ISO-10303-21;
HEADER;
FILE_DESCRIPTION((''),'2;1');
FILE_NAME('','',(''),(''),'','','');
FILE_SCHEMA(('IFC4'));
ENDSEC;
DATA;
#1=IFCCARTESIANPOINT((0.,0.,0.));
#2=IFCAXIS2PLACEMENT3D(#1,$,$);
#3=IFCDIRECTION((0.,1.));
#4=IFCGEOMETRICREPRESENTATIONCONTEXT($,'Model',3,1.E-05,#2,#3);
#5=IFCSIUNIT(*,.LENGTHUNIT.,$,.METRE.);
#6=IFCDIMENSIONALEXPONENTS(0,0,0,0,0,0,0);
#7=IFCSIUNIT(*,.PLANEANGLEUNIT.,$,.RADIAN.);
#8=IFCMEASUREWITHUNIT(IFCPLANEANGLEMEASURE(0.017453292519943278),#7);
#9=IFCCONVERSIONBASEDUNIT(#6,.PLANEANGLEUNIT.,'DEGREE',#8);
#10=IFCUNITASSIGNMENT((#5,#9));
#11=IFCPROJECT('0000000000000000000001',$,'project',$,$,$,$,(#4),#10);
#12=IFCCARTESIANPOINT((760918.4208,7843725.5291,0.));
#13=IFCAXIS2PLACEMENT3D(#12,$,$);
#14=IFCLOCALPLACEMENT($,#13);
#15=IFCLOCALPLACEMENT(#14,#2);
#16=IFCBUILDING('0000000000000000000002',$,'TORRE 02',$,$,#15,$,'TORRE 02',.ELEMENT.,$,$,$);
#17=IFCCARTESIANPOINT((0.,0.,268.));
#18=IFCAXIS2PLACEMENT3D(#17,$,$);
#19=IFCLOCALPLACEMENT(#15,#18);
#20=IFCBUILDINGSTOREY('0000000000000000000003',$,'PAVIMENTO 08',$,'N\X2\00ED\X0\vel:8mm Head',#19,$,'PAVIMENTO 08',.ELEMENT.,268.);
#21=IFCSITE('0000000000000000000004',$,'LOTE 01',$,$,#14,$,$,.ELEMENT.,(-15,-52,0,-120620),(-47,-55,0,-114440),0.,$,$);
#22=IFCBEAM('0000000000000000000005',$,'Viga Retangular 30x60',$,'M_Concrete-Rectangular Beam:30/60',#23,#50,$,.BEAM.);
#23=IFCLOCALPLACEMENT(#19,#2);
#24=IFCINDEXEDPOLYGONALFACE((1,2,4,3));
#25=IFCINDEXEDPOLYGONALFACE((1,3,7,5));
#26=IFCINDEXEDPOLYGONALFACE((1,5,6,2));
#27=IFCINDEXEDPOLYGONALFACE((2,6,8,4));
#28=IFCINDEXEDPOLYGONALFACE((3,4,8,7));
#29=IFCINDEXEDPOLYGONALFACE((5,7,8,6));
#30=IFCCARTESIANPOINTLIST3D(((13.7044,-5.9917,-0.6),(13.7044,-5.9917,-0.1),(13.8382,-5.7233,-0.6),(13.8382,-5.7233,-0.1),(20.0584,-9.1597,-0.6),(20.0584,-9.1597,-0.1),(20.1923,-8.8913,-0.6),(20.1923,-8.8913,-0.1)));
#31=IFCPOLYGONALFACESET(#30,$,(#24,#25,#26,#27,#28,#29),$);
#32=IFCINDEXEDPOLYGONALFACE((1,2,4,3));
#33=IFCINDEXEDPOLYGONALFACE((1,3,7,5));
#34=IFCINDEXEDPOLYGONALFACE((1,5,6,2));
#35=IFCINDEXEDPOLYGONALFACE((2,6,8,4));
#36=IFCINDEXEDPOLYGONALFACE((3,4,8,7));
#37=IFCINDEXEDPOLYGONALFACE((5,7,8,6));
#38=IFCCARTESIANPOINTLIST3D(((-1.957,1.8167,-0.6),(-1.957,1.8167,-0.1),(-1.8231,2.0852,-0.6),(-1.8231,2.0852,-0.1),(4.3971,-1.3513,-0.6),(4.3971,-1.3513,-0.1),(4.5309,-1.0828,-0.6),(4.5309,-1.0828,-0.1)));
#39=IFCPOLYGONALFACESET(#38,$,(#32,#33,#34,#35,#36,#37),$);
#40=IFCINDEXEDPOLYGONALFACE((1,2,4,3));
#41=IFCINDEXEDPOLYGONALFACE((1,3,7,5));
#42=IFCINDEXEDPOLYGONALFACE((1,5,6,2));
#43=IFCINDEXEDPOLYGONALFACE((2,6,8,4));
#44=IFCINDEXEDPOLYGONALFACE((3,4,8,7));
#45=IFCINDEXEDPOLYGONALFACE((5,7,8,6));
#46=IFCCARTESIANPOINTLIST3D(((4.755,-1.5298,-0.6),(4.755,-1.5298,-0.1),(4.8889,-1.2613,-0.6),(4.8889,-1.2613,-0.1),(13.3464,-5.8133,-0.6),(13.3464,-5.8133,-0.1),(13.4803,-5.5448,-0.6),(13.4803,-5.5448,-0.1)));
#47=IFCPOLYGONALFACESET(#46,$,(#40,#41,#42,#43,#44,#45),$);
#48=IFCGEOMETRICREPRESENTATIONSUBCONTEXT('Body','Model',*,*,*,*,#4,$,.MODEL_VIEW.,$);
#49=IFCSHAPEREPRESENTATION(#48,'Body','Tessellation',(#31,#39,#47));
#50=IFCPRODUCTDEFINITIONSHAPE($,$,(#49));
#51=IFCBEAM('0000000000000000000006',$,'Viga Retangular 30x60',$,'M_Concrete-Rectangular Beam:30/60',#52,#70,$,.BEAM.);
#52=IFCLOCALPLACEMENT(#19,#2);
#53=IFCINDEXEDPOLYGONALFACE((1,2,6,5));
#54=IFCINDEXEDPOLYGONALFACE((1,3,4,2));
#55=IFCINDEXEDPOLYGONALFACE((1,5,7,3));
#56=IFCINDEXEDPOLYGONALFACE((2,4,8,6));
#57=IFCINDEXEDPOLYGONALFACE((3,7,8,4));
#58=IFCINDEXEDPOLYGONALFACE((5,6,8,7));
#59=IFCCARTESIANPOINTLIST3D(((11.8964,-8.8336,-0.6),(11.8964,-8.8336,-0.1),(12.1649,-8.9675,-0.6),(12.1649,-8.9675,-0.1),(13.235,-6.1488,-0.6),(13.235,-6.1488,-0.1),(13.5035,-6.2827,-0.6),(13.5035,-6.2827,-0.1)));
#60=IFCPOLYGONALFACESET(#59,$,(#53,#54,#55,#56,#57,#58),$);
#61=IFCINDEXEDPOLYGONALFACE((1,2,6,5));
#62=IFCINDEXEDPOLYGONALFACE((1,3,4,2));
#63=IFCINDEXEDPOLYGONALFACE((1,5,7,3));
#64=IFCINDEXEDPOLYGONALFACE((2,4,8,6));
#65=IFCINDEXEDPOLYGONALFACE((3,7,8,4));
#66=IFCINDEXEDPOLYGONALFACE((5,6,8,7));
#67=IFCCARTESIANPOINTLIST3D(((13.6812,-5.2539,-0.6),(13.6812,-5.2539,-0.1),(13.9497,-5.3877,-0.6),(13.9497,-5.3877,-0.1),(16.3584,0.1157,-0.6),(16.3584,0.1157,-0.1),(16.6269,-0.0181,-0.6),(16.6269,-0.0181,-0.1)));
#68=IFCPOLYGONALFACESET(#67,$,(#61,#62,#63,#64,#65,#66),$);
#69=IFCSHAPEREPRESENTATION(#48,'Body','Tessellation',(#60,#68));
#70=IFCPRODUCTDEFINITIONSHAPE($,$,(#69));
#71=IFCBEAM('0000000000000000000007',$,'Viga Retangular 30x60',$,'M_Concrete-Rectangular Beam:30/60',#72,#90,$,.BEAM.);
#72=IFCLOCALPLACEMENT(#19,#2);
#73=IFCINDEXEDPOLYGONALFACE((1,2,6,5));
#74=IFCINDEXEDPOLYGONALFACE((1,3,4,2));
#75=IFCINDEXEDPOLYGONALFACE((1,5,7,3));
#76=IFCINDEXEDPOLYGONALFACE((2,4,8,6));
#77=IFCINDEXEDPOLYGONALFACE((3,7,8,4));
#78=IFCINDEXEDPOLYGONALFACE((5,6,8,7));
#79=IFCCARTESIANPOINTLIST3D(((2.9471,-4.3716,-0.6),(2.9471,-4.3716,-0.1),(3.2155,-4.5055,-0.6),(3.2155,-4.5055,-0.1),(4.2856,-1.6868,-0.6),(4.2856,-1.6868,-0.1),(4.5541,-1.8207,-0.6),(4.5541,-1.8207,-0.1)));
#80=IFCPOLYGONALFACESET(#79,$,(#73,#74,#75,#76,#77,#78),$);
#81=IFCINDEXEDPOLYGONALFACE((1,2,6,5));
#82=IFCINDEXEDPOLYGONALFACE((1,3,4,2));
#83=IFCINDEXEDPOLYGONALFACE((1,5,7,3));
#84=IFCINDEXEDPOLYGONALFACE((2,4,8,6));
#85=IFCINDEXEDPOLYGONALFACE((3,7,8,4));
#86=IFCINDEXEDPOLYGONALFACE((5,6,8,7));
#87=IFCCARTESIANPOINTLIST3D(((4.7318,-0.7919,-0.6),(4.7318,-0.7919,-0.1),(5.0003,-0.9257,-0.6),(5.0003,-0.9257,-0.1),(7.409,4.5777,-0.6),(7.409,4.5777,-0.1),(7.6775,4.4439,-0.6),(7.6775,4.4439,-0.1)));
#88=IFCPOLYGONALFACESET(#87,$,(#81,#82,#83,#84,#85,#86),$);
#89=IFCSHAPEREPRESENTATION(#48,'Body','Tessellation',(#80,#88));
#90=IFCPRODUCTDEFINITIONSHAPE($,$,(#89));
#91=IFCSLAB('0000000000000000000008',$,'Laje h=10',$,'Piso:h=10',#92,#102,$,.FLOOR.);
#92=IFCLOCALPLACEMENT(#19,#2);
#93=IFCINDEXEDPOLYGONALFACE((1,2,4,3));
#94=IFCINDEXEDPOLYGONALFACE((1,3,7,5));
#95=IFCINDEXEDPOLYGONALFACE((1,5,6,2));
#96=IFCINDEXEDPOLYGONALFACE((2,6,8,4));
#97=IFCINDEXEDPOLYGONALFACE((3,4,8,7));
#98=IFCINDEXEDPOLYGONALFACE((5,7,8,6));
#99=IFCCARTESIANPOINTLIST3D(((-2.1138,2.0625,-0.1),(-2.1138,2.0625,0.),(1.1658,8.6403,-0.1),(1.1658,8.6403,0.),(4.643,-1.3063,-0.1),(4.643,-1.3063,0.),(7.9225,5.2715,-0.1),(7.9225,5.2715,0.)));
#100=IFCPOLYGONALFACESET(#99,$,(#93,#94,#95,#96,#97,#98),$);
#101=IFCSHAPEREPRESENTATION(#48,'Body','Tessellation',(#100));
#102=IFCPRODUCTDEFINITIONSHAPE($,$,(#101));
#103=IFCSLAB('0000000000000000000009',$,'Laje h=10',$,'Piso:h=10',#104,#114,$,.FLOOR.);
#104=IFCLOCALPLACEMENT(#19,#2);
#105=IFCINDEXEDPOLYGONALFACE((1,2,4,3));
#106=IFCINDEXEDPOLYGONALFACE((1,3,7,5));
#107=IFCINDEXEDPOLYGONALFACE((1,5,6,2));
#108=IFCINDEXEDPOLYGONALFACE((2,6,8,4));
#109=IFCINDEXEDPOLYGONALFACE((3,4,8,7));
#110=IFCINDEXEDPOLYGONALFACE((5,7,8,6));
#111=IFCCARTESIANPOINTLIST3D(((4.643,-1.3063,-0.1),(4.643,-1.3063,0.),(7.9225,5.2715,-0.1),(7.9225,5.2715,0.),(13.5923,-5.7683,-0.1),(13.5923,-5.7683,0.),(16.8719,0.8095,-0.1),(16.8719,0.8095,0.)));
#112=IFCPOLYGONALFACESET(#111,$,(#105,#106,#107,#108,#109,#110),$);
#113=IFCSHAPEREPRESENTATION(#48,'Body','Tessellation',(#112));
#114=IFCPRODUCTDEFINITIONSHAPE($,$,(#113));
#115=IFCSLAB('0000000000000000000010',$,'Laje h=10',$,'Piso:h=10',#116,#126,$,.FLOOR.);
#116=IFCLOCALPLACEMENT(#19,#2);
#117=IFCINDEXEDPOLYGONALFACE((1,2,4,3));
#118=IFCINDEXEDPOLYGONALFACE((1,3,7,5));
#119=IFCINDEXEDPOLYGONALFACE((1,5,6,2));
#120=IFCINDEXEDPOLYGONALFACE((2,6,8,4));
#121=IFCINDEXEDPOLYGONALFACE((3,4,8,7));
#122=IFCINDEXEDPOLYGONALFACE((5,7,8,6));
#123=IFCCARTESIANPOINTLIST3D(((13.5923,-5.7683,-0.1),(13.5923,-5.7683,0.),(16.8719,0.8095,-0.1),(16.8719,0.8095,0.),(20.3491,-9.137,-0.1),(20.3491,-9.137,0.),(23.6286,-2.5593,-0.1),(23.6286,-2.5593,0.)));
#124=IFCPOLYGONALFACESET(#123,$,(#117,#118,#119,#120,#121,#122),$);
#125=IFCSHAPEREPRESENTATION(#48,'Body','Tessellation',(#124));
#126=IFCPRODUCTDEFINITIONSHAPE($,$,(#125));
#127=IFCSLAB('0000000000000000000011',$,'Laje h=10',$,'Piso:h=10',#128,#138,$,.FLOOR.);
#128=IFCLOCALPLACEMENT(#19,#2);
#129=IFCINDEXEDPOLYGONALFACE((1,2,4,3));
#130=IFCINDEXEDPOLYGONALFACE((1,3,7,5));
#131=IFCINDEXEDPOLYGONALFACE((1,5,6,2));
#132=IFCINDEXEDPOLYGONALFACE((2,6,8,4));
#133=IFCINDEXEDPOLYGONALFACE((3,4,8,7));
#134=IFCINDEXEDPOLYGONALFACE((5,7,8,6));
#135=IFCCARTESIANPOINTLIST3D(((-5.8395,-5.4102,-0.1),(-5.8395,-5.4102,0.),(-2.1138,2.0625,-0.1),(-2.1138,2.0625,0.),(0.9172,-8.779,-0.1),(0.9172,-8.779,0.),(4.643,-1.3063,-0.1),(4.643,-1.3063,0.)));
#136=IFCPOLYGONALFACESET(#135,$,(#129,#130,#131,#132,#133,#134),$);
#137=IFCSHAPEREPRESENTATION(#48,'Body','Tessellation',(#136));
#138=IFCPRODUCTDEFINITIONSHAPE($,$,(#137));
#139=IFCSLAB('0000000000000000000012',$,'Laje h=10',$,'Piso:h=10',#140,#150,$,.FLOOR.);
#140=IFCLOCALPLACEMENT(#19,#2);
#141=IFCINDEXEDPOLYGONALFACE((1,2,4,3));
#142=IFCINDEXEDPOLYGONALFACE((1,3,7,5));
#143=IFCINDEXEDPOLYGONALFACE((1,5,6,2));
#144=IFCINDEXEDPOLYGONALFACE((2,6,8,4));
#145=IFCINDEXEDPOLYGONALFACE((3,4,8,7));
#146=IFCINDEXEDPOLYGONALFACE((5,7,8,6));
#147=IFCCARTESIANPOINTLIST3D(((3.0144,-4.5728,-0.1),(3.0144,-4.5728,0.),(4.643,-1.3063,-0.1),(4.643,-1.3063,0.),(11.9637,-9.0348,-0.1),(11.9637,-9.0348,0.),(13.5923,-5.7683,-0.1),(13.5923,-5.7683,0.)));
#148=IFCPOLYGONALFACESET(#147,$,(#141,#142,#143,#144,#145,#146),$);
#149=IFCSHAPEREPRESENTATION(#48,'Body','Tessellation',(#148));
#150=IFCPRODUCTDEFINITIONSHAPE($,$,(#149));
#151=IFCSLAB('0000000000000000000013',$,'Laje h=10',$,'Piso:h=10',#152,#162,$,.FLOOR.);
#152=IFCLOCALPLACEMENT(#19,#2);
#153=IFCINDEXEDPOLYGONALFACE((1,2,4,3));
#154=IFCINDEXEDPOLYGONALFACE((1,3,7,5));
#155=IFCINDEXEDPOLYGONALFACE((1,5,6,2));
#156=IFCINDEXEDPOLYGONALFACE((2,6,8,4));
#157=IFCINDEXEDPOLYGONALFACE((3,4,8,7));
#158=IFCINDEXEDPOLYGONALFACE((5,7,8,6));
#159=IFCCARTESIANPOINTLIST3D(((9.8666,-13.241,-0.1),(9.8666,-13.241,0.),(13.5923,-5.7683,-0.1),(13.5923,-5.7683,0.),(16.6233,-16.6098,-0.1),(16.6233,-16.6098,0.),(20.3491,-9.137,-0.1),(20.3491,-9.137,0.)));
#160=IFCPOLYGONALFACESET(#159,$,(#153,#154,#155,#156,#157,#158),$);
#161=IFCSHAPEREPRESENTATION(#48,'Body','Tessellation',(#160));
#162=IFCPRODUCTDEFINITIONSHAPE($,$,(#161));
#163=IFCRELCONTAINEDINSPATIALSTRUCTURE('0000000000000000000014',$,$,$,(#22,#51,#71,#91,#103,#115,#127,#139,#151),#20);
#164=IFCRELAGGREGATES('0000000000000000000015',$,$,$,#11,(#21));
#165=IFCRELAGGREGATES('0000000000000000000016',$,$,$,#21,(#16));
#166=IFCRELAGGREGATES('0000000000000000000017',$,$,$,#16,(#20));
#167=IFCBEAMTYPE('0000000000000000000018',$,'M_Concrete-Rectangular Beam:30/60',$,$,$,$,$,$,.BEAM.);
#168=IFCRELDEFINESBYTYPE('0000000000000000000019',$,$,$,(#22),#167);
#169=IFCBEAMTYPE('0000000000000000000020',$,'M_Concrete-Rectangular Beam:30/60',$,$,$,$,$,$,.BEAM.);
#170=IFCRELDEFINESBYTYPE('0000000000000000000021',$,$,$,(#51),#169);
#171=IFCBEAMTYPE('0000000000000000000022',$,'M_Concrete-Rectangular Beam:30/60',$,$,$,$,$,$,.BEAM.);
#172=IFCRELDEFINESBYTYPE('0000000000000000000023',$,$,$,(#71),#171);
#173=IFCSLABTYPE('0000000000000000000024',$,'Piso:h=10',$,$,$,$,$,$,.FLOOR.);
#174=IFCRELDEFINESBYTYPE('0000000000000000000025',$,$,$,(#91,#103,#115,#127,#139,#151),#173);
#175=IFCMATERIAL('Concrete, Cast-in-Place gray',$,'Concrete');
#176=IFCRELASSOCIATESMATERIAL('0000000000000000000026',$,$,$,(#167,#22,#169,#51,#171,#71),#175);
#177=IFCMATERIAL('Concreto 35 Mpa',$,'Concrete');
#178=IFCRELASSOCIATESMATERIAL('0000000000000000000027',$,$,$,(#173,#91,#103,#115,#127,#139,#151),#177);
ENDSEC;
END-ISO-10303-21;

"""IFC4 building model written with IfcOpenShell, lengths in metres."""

from ifc_helpers import new_model, entity, si_unit, converted_unit, direction, frame, origin, place, context, subcontext, project, spatial, indexed_curve, outline, extrude, source, transform, mapped, material, type_object, type_shapes, element, save


model = new_model("IFC4")

# Units and contexts
model_context = context("Model", 3, precision=1e-05, world=origin(), true_north=direction((0.0, 1.0)))
body_context = subcontext(model_context, "Body", "Model", "MODEL_VIEW")
ifc_project = project(units=[si_unit("LENGTHUNIT", "METRE"), converted_unit("PLANEANGLEUNIT", "DEGREE", entity("IfcPlaneAngleMeasure", 0.017453292519943278), si_unit("PLANEANGLEUNIT", "RADIAN"), dimensions=[0, 0, 0, 0, 0, 0, 0])], contexts=[model_context])

# Site, building, storey
site_placement = place(None, frame((760918.4208, 7843725.5291, 0.0)))
site = spatial("IfcSite", under=ifc_project, at=site_placement, Name="LOTE 01", CompositionType="ELEMENT", RefLatitude=(-15, -52, 0, -120620), RefLongitude=(-47, -55, 0, -114440), RefElevation=0.0)
building_placement = place(site_placement, origin())
building = spatial("IfcBuilding", under=site, at=building_placement, Name="TORRE 02", LongName="TORRE 02", CompositionType="ELEMENT")
storey_placement = place(building_placement, frame((0.0, 0.0, 268.0)))
storey = spatial("IfcBuildingStorey", under=building, at=storey_placement, Name="PAVIMENTO 08", ObjectType="Nível:8mm Head", LongName="PAVIMENTO 08", CompositionType="ELEMENT", Elevation=268.0)

# Shared definitions
ifc_material_1 = material(Name="Concrete, Cast-in-Place gray", Category="Concrete")

# Beams
beam_type_1 = type_object("IfcBeamType", Name="M_Concrete-Rectangular Beam:30/60", PredefinedType="BEAM", material=ifc_material_1)
shared_shape_1 = source(origin(), body_context, "Body", "SweptSolid", [
    extrude(outline(indexed_curve([(-0.25, -0.15), (0.25, -0.15), (0.25, 0.15), (-0.25, 0.15), (-0.25, -0.15)], self_intersect=False)), frame((13.7713, -5.8575, 267.65), z_axis=(0.894934, -0.446198, 0.0), x_axis=(0.0, 0.0, -1.0)), (0.0, 0.0, 1.0), 7.1),
    extrude(outline(indexed_curve([(-0.25, -0.15), (0.25, -0.15), (0.25, 0.15), (-0.25, 0.15), (-0.25, -0.15)], self_intersect=False)), frame((-1.89, 1.951, 267.65), z_axis=(0.894934, -0.446198, 0.0), x_axis=(0.0, 0.0, -1.0)), (0.0, 0.0, 1.0), 7.1),
    extrude(outline(indexed_curve([(-0.25, -0.15), (0.25, -0.15), (0.25, 0.15), (-0.25, 0.15), (-0.25, -0.15)], self_intersect=False)), frame((4.822, -1.3955, 267.65), z_axis=(0.894934, -0.446198, 0.0), x_axis=(0.0, 0.0, -1.0)), (0.0, 0.0, 1.0), 9.6),
])
type_shapes(beam_type_1, [shared_shape_1])
beam_1_placement = place(storey_placement, frame((0.0, 0.0, -268.0)))
element("IfcBeam", 1, at=beam_1_placement, inside=storey, type_object=beam_type_1, material=ifc_material_1, Name="Viga Retangular 30x60", ObjectType="M_Concrete-Rectangular Beam:30/60", PredefinedType="BEAM", context=body_context, shape_type="MappedRepresentation", body=[
    mapped(shared_shape_1, transform((0.0, 0.0, 0.0), scale=1.0)),
])
beam_type_2 = type_object("IfcBeamType", Name="M_Concrete-Rectangular Beam:30/60", PredefinedType="BEAM", material=ifc_material_1)
shared_shape_2 = source(origin(), body_context, "Body", "SweptSolid", [
    extrude(outline(indexed_curve([(-0.25, -0.15), (0.25, -0.15), (0.25, 0.15), (-0.25, 0.15), (-0.25, -0.15)], self_intersect=False)), frame((12.0306, -8.9005, 267.65), z_axis=(0.446198, 0.894934, 0.0), x_axis=(0.0, 0.0, 1.0)), (0.0, 0.0, 1.0), 3.0),
    extrude(outline(indexed_curve([(-0.25, -0.15), (0.25, -0.15), (0.25, 0.15), (-0.25, 0.15), (-0.25, -0.15)], self_intersect=False)), frame((13.8154, -5.3208, 267.65), z_axis=(0.446198, 0.894934, 0.0), x_axis=(0.0, 0.0, 1.0)), (0.0, 0.0, 1.0), 6.0),
])
type_shapes(beam_type_2, [shared_shape_2])
beam_2_placement = place(storey_placement, frame((0.0, 0.0, -268.0)))
element("IfcBeam", 2, at=beam_2_placement, inside=storey, type_object=beam_type_2, material=ifc_material_1, Name="Viga Retangular 30x60", ObjectType="M_Concrete-Rectangular Beam:30/60", PredefinedType="BEAM", context=body_context, shape_type="MappedRepresentation", body=[
    mapped(shared_shape_2, transform((0.0, 0.0, 0.0), scale=1.0)),
])
beam_type_3 = type_object("IfcBeamType", Name="M_Concrete-Rectangular Beam:30/60", PredefinedType="BEAM", material=ifc_material_1)
shared_shape_3 = source(origin(), body_context, "Body", "SweptSolid", [
    extrude(outline(indexed_curve([(-0.25, -0.15), (0.25, -0.15), (0.25, 0.15), (-0.25, 0.15), (-0.25, -0.15)], self_intersect=False)), frame((3.0813, -4.4385, 267.65), z_axis=(0.446198, 0.894934, 0.0), x_axis=(0.0, 0.0, 1.0)), (0.0, 0.0, 1.0), 3.0),
    extrude(outline(indexed_curve([(-0.25, -0.15), (0.25, -0.15), (0.25, 0.15), (-0.25, 0.15), (-0.25, -0.15)], self_intersect=False)), frame((4.8661, -0.8588, 267.65), z_axis=(0.446198, 0.894934, 0.0), x_axis=(0.0, 0.0, 1.0)), (0.0, 0.0, 1.0), 6.0),
])
type_shapes(beam_type_3, [shared_shape_3])
beam_3_placement = place(storey_placement, frame((0.0, 0.0, -268.0)))
element("IfcBeam", 3, at=beam_3_placement, inside=storey, type_object=beam_type_3, material=ifc_material_1, Name="Viga Retangular 30x60", ObjectType="M_Concrete-Rectangular Beam:30/60", PredefinedType="BEAM", context=body_context, shape_type="MappedRepresentation", body=[
    mapped(shared_shape_3, transform((0.0, 0.0, 0.0), scale=1.0)),
])

# Slabs
ifc_material_2 = material(Name="Concreto 35 Mpa", Category="Concrete")
slab_type = type_object("IfcSlabType", Name="Piso:h=10", PredefinedType="FLOOR", material=ifc_material_2)
slab_1_placement = place(storey_placement, origin())
element("IfcSlab", 4, at=slab_1_placement, inside=storey, type_object=slab_type, material=ifc_material_2, Name="Laje h=10", ObjectType="Piso:h=10", PredefinedType="FLOOR", context=body_context, shape_type="SweptSolid", body=[
    extrude(outline(indexed_curve([(-3.675, -3.775), (3.675, -3.775), (3.675, 3.775), (-3.675, 3.775), (-3.675, -3.775)], self_intersect=False)), frame((2.9044, 3.667, 0.0), z_axis=(0.0, 0.0, -1.0), x_axis=(-0.446198, -0.894934, 0.0)), (0.0, 0.0, 1.0), 0.1),
])
slab_2_placement = place(storey_placement, origin())
element("IfcSlab", 5, at=slab_2_placement, inside=storey, type_object=slab_type, material=ifc_material_2, Name="Laje h=10", ObjectType="Piso:h=10", PredefinedType="FLOOR", context=body_context, shape_type="SweptSolid", body=[
    extrude(outline(indexed_curve([(-3.675, -5.0), (3.675, -5.0), (3.675, 5.0), (-3.675, 5.0), (-3.675, -5.0)], self_intersect=False)), frame((10.7574, -0.2484, 0.0), z_axis=(0.0, 0.0, -1.0), x_axis=(-0.446198, -0.894934, 0.0)), (0.0, 0.0, 1.0), 0.1),
])
slab_3_placement = place(storey_placement, origin())
element("IfcSlab", 6, at=slab_3_placement, inside=storey, type_object=slab_type, material=ifc_material_2, Name="Laje h=10", ObjectType="Piso:h=10", PredefinedType="FLOOR", context=body_context, shape_type="SweptSolid", body=[
    extrude(outline(indexed_curve([(-3.675, -3.775), (3.675, -3.775), (3.675, 3.775), (-3.675, 3.775), (-3.675, -3.775)], self_intersect=False)), frame((18.6105, -4.1638, 0.0), z_axis=(0.0, 0.0, -1.0), x_axis=(-0.446198, -0.894934, 0.0)), (0.0, 0.0, 1.0), 0.1),
])
slab_4_placement = place(storey_placement, origin())
element("IfcSlab", 7, at=slab_4_placement, inside=storey, type_object=slab_type, material=ifc_material_2, Name="Laje h=10", ObjectType="Piso:h=10", PredefinedType="FLOOR", context=body_context, shape_type="SweptSolid", body=[
    extrude(outline(indexed_curve([(-4.175, -3.775), (4.175, -3.775), (4.175, 3.775), (-4.175, 3.775), (-4.175, -3.775)], self_intersect=False)), frame((-0.5983, -3.3582, 0.0), z_axis=(0.0, 0.0, -1.0), x_axis=(-0.446198, -0.894934, 0.0)), (0.0, 0.0, 1.0), 0.1),
])
slab_5_placement = place(storey_placement, origin())
element("IfcSlab", 8, at=slab_5_placement, inside=storey, type_object=slab_type, material=ifc_material_2, Name="Laje h=10", ObjectType="Piso:h=10", PredefinedType="FLOOR", context=body_context, shape_type="SweptSolid", body=[
    extrude(outline(indexed_curve([(-1.825, -5.0), (1.825, -5.0), (1.825, 5.0), (-1.825, 5.0), (-1.825, -5.0)], self_intersect=False)), frame((8.3033, -5.1705, 0.0), z_axis=(0.0, 0.0, -1.0), x_axis=(-0.446198, -0.894934, 0.0)), (0.0, 0.0, 1.0), 0.1),
])
slab_6_placement = place(storey_placement, origin())
element("IfcSlab", 9, at=slab_6_placement, inside=storey, type_object=slab_type, material=ifc_material_2, Name="Laje h=10", ObjectType="Piso:h=10", PredefinedType="FLOOR", context=body_context, shape_type="SweptSolid", body=[
    extrude(outline(indexed_curve([(-4.175, -3.775), (4.175, -3.775), (4.175, 3.775), (-4.175, 3.775), (-4.175, -3.775)], self_intersect=False)), frame((15.1078, -11.189, 0.0), z_axis=(0.0, 0.0, -1.0), x_axis=(-0.446198, -0.894934, 0.0)), (0.0, 0.0, 1.0), 0.1),
])

save(model, "model.ifc")
